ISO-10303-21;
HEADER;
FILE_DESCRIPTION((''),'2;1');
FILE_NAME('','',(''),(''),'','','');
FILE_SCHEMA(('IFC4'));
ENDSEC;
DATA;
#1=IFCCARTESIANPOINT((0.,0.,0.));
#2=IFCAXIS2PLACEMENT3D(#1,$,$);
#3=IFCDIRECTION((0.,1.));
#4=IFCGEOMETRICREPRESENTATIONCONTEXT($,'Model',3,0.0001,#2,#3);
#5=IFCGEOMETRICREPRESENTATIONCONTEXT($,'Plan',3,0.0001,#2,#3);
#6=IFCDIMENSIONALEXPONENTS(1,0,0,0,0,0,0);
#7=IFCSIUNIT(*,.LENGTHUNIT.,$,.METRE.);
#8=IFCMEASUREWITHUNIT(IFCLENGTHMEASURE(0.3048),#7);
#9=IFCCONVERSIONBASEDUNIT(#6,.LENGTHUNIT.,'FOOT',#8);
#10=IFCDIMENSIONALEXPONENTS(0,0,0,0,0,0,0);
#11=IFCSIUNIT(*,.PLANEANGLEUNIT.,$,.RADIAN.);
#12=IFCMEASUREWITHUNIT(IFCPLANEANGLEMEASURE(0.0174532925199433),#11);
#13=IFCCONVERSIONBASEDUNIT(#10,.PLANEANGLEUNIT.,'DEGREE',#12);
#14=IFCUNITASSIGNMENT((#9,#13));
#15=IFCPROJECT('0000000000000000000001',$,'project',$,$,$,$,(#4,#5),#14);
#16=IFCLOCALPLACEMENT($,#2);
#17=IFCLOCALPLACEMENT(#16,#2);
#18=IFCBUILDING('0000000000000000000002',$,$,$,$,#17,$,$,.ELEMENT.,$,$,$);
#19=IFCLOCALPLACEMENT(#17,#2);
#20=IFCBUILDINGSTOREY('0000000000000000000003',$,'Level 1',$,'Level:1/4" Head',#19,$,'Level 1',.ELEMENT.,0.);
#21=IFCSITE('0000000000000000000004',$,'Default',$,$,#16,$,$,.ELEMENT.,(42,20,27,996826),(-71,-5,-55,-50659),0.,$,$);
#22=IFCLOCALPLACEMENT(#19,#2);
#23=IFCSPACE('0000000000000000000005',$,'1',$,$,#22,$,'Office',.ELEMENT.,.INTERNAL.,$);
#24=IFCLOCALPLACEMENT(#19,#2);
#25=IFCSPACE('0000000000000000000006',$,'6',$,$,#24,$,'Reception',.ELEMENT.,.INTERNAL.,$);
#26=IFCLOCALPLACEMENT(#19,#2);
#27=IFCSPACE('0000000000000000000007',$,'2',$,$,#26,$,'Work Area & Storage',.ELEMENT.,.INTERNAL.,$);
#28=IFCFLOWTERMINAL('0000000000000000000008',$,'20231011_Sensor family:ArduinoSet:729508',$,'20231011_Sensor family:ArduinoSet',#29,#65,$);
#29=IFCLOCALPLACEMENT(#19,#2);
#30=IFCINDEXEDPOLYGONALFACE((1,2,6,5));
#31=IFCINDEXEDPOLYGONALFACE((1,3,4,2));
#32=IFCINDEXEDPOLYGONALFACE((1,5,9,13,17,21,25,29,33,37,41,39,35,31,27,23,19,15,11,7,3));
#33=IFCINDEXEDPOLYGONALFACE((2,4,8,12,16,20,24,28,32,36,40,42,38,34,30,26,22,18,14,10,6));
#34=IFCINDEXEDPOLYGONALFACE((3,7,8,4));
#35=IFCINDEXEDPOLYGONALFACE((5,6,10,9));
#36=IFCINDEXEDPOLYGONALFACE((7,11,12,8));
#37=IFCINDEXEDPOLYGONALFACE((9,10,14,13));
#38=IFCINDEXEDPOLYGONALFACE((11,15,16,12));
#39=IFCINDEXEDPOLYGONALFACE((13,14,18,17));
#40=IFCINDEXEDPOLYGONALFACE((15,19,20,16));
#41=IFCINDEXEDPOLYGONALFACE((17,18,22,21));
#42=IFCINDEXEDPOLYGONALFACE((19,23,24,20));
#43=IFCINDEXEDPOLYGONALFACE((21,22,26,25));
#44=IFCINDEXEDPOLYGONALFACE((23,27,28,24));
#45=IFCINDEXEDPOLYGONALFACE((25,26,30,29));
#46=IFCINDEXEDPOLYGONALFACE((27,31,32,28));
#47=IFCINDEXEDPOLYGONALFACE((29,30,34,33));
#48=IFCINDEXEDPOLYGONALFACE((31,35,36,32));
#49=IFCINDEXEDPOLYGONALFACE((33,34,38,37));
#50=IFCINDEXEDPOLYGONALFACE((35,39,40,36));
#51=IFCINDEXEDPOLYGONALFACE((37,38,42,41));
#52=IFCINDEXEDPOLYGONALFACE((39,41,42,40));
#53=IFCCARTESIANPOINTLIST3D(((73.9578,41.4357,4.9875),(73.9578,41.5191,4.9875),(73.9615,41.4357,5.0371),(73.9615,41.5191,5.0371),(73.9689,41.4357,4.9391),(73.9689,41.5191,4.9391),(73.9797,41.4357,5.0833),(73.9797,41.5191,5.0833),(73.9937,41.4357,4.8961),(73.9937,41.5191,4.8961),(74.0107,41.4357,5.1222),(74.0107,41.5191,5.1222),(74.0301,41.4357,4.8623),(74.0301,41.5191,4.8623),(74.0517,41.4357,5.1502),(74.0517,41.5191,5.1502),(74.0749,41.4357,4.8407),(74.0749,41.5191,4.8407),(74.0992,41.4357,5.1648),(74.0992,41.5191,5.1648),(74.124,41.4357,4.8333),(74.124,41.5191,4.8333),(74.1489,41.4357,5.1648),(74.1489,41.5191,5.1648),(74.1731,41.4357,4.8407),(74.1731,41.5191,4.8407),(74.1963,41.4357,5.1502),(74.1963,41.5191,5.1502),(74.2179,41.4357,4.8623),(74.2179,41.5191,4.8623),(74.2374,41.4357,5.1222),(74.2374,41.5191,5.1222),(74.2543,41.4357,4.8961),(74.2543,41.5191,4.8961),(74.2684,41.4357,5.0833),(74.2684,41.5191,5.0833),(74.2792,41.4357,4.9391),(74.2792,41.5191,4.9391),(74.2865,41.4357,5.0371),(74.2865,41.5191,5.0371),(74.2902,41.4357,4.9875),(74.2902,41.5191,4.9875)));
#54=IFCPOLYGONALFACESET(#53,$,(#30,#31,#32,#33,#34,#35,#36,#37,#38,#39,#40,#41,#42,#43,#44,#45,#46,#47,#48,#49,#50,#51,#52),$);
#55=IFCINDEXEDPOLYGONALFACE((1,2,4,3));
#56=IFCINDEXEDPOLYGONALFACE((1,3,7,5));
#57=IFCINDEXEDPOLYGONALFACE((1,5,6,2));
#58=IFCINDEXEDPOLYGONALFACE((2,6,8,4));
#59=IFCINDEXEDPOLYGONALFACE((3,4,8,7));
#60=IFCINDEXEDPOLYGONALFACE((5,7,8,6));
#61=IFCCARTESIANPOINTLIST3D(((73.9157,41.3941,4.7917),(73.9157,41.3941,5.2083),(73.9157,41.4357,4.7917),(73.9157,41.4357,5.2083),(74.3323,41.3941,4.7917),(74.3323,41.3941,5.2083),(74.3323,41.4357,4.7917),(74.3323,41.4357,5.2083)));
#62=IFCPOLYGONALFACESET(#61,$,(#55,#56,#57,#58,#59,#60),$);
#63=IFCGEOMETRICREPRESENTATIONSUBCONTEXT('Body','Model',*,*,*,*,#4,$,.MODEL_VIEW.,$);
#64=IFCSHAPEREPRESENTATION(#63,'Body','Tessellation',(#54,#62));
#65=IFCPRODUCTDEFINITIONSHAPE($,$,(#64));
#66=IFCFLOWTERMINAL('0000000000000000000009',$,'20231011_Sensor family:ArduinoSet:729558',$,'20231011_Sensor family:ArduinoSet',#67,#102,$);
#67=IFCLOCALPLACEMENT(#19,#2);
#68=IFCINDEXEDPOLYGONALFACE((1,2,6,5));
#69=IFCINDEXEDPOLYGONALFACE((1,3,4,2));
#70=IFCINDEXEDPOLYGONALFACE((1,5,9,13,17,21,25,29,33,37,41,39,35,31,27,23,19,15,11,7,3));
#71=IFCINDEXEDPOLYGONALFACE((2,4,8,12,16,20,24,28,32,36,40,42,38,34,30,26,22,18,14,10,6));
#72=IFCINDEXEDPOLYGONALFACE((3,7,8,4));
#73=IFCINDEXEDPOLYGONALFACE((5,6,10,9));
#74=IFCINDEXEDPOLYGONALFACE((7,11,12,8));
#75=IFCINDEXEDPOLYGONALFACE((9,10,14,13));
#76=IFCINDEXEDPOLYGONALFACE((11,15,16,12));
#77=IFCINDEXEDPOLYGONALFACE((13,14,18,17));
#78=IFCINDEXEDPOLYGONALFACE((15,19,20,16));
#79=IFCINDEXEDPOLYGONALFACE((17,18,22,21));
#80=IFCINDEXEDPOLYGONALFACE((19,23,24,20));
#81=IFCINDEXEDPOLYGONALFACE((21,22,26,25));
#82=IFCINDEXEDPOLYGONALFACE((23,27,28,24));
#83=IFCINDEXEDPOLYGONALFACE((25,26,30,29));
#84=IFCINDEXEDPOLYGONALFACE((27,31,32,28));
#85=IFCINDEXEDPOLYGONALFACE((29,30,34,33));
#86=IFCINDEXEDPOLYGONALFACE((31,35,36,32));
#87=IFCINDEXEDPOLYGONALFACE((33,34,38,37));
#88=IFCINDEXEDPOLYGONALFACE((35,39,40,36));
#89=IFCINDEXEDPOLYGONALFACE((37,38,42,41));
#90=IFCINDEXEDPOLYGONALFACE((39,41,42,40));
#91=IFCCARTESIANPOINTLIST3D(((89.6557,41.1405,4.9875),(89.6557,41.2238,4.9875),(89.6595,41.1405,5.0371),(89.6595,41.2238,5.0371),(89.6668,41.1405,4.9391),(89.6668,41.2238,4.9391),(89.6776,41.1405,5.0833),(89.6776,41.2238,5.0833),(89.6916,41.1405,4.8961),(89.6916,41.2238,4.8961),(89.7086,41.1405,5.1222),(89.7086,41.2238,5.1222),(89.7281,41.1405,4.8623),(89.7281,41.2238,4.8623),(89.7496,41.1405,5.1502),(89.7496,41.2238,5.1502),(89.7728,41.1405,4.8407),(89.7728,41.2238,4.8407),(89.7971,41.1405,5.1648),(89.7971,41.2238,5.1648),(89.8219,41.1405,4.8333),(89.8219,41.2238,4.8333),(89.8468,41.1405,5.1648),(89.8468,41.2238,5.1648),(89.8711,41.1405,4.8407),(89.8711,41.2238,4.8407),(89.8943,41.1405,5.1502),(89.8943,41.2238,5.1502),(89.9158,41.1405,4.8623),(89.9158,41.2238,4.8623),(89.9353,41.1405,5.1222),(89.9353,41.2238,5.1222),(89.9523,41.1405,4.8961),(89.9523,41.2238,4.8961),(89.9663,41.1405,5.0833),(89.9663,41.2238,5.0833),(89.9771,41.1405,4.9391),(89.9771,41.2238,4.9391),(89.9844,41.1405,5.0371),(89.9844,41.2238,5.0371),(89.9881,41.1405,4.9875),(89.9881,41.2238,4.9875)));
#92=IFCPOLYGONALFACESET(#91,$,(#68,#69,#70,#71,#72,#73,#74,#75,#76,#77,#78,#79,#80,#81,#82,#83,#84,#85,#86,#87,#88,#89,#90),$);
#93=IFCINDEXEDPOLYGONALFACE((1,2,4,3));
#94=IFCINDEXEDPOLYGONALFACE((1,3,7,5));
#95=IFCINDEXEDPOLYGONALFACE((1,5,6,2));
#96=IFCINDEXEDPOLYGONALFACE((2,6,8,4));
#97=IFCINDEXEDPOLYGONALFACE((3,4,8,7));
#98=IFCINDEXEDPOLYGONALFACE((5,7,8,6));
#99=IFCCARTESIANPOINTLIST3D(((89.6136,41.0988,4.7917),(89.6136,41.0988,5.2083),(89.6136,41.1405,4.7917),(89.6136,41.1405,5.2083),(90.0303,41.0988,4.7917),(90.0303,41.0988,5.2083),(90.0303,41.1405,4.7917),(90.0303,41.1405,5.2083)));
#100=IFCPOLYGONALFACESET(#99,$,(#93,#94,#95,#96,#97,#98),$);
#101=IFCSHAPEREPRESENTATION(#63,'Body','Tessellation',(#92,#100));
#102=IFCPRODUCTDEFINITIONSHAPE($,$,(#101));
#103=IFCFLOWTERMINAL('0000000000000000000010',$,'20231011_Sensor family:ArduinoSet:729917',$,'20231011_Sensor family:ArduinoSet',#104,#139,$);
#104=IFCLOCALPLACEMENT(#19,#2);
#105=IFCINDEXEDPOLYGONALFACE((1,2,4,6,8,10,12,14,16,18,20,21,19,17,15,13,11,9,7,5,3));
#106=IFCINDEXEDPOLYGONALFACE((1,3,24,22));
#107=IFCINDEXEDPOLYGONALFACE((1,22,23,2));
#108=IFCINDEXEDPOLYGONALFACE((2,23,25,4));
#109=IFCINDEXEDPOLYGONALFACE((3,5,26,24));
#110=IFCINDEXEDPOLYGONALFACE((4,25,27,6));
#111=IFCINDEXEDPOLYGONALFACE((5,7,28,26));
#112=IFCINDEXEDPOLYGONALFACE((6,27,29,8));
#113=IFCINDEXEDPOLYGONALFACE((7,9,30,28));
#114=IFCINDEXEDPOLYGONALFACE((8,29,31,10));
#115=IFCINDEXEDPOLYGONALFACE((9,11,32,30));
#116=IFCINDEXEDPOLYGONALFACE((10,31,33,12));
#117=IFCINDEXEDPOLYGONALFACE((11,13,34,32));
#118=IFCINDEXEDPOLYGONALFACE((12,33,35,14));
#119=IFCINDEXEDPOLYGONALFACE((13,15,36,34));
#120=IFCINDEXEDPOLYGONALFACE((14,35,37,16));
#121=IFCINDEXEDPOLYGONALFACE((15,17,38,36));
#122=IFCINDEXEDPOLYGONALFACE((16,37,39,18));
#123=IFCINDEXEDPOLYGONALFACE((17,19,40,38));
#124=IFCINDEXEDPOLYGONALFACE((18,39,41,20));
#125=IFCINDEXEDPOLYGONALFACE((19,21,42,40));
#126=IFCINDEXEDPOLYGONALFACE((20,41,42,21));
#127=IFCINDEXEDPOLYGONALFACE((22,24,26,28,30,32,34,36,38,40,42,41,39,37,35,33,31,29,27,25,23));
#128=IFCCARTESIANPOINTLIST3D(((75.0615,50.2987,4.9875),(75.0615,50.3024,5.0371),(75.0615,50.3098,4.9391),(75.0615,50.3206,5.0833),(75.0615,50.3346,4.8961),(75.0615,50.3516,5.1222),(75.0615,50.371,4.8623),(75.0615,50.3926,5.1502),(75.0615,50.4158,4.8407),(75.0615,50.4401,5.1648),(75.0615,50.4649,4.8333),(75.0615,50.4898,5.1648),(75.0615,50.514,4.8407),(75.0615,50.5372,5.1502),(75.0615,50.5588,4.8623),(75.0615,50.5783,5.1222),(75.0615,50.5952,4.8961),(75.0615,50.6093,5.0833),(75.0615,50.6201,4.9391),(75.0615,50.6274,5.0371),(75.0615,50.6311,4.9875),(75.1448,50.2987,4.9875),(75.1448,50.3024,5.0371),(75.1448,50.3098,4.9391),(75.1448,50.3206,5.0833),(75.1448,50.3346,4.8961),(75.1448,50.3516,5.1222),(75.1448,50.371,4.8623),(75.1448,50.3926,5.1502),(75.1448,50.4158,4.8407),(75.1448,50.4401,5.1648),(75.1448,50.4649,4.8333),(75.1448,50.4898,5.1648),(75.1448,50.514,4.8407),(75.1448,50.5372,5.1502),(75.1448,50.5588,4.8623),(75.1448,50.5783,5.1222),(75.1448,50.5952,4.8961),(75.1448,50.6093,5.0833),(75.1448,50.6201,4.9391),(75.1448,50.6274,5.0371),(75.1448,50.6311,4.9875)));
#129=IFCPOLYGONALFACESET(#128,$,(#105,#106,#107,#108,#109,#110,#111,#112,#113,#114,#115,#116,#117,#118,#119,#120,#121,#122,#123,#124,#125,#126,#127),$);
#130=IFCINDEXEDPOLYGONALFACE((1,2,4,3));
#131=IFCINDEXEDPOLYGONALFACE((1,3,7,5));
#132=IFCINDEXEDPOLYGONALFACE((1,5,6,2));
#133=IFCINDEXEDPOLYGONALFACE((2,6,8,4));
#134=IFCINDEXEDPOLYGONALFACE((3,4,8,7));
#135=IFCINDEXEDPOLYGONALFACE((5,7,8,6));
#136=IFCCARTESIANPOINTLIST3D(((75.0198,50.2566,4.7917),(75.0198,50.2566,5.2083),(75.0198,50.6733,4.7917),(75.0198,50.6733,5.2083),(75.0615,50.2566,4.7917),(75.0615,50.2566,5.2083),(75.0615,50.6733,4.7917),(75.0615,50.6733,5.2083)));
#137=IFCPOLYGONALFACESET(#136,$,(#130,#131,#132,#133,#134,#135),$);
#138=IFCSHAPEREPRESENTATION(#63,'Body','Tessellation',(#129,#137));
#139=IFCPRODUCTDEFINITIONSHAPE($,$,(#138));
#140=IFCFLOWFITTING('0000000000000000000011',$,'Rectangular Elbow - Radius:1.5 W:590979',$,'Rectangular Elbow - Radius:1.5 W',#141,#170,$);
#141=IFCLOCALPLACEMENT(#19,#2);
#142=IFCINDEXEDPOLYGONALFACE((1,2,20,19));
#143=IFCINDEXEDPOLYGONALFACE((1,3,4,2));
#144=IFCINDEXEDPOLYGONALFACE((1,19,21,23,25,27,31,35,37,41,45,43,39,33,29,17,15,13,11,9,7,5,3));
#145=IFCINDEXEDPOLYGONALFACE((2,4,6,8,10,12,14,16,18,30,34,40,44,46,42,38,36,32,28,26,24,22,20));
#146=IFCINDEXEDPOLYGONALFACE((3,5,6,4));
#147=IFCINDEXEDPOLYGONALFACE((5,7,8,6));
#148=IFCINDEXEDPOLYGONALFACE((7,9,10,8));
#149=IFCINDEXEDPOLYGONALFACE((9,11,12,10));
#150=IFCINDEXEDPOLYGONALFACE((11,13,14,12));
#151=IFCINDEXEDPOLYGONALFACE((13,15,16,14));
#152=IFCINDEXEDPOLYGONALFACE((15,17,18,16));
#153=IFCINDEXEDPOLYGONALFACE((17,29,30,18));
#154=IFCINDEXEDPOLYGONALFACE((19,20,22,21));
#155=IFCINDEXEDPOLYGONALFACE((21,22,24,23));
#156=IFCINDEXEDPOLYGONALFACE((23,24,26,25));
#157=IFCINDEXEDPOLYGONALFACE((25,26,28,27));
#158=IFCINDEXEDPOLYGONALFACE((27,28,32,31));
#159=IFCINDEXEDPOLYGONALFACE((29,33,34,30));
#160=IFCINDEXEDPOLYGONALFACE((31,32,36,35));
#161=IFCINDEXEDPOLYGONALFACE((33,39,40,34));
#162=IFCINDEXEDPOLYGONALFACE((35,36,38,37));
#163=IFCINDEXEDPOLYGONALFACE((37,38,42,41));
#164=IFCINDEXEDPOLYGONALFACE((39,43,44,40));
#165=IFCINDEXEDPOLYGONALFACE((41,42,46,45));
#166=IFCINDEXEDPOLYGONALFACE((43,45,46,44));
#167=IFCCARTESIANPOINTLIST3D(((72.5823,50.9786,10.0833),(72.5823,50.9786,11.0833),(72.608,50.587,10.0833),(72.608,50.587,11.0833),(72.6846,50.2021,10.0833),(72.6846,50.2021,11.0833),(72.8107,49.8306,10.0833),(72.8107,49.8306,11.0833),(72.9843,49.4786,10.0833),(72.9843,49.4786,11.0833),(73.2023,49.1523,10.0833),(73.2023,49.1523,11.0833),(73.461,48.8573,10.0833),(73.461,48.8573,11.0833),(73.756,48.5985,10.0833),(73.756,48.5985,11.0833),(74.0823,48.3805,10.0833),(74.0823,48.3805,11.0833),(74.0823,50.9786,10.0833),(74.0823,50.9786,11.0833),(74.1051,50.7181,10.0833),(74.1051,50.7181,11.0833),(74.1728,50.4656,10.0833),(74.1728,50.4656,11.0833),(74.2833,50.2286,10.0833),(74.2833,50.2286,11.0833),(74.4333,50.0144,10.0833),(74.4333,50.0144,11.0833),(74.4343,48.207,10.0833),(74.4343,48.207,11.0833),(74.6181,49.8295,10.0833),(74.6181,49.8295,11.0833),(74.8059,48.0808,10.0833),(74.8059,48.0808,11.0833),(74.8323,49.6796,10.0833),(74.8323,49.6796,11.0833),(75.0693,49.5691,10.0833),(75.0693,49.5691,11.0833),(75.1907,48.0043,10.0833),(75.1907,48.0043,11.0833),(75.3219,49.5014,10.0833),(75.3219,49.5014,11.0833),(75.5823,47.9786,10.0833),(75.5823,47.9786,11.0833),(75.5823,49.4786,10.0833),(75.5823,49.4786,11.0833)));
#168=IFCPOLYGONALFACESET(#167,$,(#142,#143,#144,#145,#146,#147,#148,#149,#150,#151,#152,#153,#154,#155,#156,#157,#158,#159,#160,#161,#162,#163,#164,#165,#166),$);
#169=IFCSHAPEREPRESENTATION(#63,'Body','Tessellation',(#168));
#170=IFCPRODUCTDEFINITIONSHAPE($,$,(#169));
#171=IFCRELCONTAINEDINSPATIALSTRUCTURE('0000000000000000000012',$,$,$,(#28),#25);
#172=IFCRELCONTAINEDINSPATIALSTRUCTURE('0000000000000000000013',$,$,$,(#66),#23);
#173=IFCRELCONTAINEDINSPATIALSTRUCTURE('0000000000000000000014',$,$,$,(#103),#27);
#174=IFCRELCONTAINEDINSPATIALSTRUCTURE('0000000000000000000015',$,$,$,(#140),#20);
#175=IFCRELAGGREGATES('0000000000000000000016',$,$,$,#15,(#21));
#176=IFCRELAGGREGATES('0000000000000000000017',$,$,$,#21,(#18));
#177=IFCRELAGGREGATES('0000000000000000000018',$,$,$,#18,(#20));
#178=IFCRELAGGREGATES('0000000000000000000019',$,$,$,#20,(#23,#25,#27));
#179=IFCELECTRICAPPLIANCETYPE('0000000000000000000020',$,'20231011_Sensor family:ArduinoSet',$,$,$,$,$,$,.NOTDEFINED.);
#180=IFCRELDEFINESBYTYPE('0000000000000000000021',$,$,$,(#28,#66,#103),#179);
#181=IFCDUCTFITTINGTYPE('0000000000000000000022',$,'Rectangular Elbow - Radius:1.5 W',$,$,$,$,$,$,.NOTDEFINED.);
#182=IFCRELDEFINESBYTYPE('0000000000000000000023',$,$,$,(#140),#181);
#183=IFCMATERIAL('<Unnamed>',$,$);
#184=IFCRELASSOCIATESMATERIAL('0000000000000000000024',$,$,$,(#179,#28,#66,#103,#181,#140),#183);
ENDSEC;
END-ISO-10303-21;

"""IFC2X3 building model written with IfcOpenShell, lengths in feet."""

from ifc_helpers import new_model, entity, si_unit, converted_unit, direction, frame, frame_2d, origin, origin_2d_with_axis, place, context, subcontext, project, spatial, polyline, circle_curve, parameter, trimmed, segment, composite_curve, rectangle, circle, outline, extrude, source, transform, mapped, material, type_object, type_shapes, element, save


model = new_model("IFC2X3")

# Units and contexts
model_context = context("Model", 3, precision=0.0001, world=origin(), true_north=direction((0.0, 1.0)))
plan_context = context("Plan", 3, precision=0.0001, world=origin(), true_north=direction((0.0, 1.0)))
body_context = subcontext(model_context, "Body", "Model", "MODEL_VIEW")
ifc_project = project(units=[converted_unit("LENGTHUNIT", "FOOT", entity("IfcLengthMeasure", 0.3048), si_unit("LENGTHUNIT", "METRE"), dimensions=[1, 0, 0, 0, 0, 0, 0]), converted_unit("PLANEANGLEUNIT", "DEGREE", entity("IfcPlaneAngleMeasure", 0.0174532925199433), si_unit("PLANEANGLEUNIT", "RADIAN"), dimensions=[0, 0, 0, 0, 0, 0, 0])], contexts=[model_context, plan_context])

# Site, building, storey
site_placement = place(None, origin())
site = spatial("IfcSite", under=ifc_project, at=site_placement, Name="Default", CompositionType="ELEMENT", RefLatitude=(42, 20, 27, 996826), RefLongitude=(-71, -5, -55, -50659), RefElevation=0.0)
building_placement = place(site_placement, origin())
building = spatial("IfcBuilding", under=site, at=building_placement, CompositionType="ELEMENT")
storey_placement = place(building_placement, origin())
storey = spatial("IfcBuildingStorey", under=building, at=storey_placement, Name="Level 1", ObjectType="Level:1/4\" Head", LongName="Level 1", CompositionType="ELEMENT", Elevation=0.0)

# Shared definitions
ifc_material_1 = material(Name="<Unnamed>")

# Shared definitions
space_1_placement = place(storey_placement, origin())
space_1 = spatial("IfcSpace", under=storey, at=space_1_placement, Name="1", LongName="Office", CompositionType="ELEMENT", InteriorOrExteriorSpace="INTERNAL")

# Shared definitions
electric_appliance_type_1 = type_object("IfcElectricApplianceType", Name="20231011_Sensor family:ArduinoSet", PredefinedType="NOTDEFINED", material=ifc_material_1)
shared_shape_1 = source(origin(), body_context, "Body", "SweptSolid", [
    extrude(circle(Radius=0.1667, at=frame_2d((0.0, 0.0), x_axis=(1.0, 0.0))), frame((0.0417, 0.0, 0.0), z_axis=(1.0, 0.0, 0.0), x_axis=(0.0, 0.0, -1.0)), (0.0, 0.0, 1.0), 0.0833),
    extrude(rectangle(XDim=0.0417, YDim=0.4167, at=origin_2d_with_axis()), frame((0.0208, 0.0, -0.2083), z_axis=(0.0, 0.0, 1.0), x_axis=(-1.0, 0.0, 0.0)), (0.0, 0.0, 1.0), 0.4167),
])
type_shapes(electric_appliance_type_1, [shared_shape_1])

# Shared definitions
space_2_placement = place(storey_placement, origin())
space_2 = spatial("IfcSpace", under=storey, at=space_2_placement, Name="6", LongName="Reception", CompositionType="ELEMENT", InteriorOrExteriorSpace="INTERNAL")

# Flow terminals
flow_terminal_1_placement = place(space_2_placement, frame((74.124, 41.3941, 5.0), z_axis=(0.0, 0.0, 1.0), x_axis=(0.0, 1.0, 0.0)))
element("IfcFlowTerminal", 1, at=flow_terminal_1_placement, inside=space_2, type_object=electric_appliance_type_1, material=ifc_material_1, Name="20231011_Sensor family:ArduinoSet:729508", ObjectType="20231011_Sensor family:ArduinoSet", context=body_context, shape_type="MappedRepresentation", body=[
    mapped(shared_shape_1, transform((0.0, 0.0, 0.0), scale=1.0)),
])
flow_terminal_2_placement = place(space_1_placement, frame((89.8219, 41.0988, 5.0), z_axis=(0.0, 0.0, 1.0), x_axis=(0.0, 1.0, 0.0)))
element("IfcFlowTerminal", 2, at=flow_terminal_2_placement, inside=space_1, type_object=electric_appliance_type_1, material=ifc_material_1, Name="20231011_Sensor family:ArduinoSet:729558", ObjectType="20231011_Sensor family:ArduinoSet", context=body_context, shape_type="MappedRepresentation", body=[
    mapped(shared_shape_1, transform((0.0, 0.0, 0.0), scale=1.0)),
])

# Shared definitions
space_3_placement = place(storey_placement, origin())
space_3 = spatial("IfcSpace", under=storey, at=space_3_placement, Name="2", LongName="Work Area & Storage", CompositionType="ELEMENT", InteriorOrExteriorSpace="INTERNAL")

# Flow terminal
flow_terminal_3_placement = place(space_3_placement, frame((75.0198, 50.4649, 5.0)))
element("IfcFlowTerminal", 3, at=flow_terminal_3_placement, inside=space_3, type_object=electric_appliance_type_1, material=ifc_material_1, Name="20231011_Sensor family:ArduinoSet:729917", ObjectType="20231011_Sensor family:ArduinoSet", context=body_context, shape_type="MappedRepresentation", body=[
    mapped(shared_shape_1, transform((0.0, 0.0, 0.0), scale=1.0)),
])

# Flow fitting
duct_fitting_type_1 = type_object("IfcDuctFittingType", Name="Rectangular Elbow - Radius:1.5 W", PredefinedType="NOTDEFINED", material=ifc_material_1)
shared_shape_2 = source(origin(), body_context, "Body", "SweptSolid", [
    extrude(outline(composite_curve([segment(polyline([(-1.875, -1.125), (-0.375, -1.125)]), True, "CONTINUOUS"), segment(trimmed(circle_curve(frame_2d((1.125, -1.125), x_axis=(0.0, 1.0)), 1.5), [parameter(0.0)], [parameter(90.0)], True, "PARAMETER"), False, "CONTINUOUS"), segment(polyline([(1.125, 0.375), (1.125, 1.875)]), True, "CONTINUOUS"), segment(trimmed(circle_curve(frame_2d((1.125, -1.125), x_axis=(0.0, 1.0)), 3.0), [parameter(0.0)], [parameter(90.0)], True, "PARAMETER"), True, "CONTINUOUS")], self_intersect=False)), frame((-1.125, 1.125, -0.5), z_axis=(0.0, 0.0, 1.0), x_axis=(-1.0, 0.0, 0.0)), (0.0, 0.0, 1.0), 1.0),
])
type_shapes(duct_fitting_type_1, [shared_shape_2])
flow_fitting_1_placement = place(storey_placement, frame((73.3323, 48.7286, 10.5833), z_axis=(0.0, 0.0, 1.0), x_axis=(0.0, -1.0, 0.0)))
element("IfcFlowFitting", 4, at=flow_fitting_1_placement, inside=storey, type_object=duct_fitting_type_1, material=ifc_material_1, Name="Rectangular Elbow - Radius:1.5 W:590979", ObjectType="Rectangular Elbow - Radius:1.5 W", context=body_context, shape_type="MappedRepresentation", body=[
    mapped(shared_shape_2, transform((0.0, 0.0, 0.0), scale=1.0)),
])

save(model, "model.ifc")
